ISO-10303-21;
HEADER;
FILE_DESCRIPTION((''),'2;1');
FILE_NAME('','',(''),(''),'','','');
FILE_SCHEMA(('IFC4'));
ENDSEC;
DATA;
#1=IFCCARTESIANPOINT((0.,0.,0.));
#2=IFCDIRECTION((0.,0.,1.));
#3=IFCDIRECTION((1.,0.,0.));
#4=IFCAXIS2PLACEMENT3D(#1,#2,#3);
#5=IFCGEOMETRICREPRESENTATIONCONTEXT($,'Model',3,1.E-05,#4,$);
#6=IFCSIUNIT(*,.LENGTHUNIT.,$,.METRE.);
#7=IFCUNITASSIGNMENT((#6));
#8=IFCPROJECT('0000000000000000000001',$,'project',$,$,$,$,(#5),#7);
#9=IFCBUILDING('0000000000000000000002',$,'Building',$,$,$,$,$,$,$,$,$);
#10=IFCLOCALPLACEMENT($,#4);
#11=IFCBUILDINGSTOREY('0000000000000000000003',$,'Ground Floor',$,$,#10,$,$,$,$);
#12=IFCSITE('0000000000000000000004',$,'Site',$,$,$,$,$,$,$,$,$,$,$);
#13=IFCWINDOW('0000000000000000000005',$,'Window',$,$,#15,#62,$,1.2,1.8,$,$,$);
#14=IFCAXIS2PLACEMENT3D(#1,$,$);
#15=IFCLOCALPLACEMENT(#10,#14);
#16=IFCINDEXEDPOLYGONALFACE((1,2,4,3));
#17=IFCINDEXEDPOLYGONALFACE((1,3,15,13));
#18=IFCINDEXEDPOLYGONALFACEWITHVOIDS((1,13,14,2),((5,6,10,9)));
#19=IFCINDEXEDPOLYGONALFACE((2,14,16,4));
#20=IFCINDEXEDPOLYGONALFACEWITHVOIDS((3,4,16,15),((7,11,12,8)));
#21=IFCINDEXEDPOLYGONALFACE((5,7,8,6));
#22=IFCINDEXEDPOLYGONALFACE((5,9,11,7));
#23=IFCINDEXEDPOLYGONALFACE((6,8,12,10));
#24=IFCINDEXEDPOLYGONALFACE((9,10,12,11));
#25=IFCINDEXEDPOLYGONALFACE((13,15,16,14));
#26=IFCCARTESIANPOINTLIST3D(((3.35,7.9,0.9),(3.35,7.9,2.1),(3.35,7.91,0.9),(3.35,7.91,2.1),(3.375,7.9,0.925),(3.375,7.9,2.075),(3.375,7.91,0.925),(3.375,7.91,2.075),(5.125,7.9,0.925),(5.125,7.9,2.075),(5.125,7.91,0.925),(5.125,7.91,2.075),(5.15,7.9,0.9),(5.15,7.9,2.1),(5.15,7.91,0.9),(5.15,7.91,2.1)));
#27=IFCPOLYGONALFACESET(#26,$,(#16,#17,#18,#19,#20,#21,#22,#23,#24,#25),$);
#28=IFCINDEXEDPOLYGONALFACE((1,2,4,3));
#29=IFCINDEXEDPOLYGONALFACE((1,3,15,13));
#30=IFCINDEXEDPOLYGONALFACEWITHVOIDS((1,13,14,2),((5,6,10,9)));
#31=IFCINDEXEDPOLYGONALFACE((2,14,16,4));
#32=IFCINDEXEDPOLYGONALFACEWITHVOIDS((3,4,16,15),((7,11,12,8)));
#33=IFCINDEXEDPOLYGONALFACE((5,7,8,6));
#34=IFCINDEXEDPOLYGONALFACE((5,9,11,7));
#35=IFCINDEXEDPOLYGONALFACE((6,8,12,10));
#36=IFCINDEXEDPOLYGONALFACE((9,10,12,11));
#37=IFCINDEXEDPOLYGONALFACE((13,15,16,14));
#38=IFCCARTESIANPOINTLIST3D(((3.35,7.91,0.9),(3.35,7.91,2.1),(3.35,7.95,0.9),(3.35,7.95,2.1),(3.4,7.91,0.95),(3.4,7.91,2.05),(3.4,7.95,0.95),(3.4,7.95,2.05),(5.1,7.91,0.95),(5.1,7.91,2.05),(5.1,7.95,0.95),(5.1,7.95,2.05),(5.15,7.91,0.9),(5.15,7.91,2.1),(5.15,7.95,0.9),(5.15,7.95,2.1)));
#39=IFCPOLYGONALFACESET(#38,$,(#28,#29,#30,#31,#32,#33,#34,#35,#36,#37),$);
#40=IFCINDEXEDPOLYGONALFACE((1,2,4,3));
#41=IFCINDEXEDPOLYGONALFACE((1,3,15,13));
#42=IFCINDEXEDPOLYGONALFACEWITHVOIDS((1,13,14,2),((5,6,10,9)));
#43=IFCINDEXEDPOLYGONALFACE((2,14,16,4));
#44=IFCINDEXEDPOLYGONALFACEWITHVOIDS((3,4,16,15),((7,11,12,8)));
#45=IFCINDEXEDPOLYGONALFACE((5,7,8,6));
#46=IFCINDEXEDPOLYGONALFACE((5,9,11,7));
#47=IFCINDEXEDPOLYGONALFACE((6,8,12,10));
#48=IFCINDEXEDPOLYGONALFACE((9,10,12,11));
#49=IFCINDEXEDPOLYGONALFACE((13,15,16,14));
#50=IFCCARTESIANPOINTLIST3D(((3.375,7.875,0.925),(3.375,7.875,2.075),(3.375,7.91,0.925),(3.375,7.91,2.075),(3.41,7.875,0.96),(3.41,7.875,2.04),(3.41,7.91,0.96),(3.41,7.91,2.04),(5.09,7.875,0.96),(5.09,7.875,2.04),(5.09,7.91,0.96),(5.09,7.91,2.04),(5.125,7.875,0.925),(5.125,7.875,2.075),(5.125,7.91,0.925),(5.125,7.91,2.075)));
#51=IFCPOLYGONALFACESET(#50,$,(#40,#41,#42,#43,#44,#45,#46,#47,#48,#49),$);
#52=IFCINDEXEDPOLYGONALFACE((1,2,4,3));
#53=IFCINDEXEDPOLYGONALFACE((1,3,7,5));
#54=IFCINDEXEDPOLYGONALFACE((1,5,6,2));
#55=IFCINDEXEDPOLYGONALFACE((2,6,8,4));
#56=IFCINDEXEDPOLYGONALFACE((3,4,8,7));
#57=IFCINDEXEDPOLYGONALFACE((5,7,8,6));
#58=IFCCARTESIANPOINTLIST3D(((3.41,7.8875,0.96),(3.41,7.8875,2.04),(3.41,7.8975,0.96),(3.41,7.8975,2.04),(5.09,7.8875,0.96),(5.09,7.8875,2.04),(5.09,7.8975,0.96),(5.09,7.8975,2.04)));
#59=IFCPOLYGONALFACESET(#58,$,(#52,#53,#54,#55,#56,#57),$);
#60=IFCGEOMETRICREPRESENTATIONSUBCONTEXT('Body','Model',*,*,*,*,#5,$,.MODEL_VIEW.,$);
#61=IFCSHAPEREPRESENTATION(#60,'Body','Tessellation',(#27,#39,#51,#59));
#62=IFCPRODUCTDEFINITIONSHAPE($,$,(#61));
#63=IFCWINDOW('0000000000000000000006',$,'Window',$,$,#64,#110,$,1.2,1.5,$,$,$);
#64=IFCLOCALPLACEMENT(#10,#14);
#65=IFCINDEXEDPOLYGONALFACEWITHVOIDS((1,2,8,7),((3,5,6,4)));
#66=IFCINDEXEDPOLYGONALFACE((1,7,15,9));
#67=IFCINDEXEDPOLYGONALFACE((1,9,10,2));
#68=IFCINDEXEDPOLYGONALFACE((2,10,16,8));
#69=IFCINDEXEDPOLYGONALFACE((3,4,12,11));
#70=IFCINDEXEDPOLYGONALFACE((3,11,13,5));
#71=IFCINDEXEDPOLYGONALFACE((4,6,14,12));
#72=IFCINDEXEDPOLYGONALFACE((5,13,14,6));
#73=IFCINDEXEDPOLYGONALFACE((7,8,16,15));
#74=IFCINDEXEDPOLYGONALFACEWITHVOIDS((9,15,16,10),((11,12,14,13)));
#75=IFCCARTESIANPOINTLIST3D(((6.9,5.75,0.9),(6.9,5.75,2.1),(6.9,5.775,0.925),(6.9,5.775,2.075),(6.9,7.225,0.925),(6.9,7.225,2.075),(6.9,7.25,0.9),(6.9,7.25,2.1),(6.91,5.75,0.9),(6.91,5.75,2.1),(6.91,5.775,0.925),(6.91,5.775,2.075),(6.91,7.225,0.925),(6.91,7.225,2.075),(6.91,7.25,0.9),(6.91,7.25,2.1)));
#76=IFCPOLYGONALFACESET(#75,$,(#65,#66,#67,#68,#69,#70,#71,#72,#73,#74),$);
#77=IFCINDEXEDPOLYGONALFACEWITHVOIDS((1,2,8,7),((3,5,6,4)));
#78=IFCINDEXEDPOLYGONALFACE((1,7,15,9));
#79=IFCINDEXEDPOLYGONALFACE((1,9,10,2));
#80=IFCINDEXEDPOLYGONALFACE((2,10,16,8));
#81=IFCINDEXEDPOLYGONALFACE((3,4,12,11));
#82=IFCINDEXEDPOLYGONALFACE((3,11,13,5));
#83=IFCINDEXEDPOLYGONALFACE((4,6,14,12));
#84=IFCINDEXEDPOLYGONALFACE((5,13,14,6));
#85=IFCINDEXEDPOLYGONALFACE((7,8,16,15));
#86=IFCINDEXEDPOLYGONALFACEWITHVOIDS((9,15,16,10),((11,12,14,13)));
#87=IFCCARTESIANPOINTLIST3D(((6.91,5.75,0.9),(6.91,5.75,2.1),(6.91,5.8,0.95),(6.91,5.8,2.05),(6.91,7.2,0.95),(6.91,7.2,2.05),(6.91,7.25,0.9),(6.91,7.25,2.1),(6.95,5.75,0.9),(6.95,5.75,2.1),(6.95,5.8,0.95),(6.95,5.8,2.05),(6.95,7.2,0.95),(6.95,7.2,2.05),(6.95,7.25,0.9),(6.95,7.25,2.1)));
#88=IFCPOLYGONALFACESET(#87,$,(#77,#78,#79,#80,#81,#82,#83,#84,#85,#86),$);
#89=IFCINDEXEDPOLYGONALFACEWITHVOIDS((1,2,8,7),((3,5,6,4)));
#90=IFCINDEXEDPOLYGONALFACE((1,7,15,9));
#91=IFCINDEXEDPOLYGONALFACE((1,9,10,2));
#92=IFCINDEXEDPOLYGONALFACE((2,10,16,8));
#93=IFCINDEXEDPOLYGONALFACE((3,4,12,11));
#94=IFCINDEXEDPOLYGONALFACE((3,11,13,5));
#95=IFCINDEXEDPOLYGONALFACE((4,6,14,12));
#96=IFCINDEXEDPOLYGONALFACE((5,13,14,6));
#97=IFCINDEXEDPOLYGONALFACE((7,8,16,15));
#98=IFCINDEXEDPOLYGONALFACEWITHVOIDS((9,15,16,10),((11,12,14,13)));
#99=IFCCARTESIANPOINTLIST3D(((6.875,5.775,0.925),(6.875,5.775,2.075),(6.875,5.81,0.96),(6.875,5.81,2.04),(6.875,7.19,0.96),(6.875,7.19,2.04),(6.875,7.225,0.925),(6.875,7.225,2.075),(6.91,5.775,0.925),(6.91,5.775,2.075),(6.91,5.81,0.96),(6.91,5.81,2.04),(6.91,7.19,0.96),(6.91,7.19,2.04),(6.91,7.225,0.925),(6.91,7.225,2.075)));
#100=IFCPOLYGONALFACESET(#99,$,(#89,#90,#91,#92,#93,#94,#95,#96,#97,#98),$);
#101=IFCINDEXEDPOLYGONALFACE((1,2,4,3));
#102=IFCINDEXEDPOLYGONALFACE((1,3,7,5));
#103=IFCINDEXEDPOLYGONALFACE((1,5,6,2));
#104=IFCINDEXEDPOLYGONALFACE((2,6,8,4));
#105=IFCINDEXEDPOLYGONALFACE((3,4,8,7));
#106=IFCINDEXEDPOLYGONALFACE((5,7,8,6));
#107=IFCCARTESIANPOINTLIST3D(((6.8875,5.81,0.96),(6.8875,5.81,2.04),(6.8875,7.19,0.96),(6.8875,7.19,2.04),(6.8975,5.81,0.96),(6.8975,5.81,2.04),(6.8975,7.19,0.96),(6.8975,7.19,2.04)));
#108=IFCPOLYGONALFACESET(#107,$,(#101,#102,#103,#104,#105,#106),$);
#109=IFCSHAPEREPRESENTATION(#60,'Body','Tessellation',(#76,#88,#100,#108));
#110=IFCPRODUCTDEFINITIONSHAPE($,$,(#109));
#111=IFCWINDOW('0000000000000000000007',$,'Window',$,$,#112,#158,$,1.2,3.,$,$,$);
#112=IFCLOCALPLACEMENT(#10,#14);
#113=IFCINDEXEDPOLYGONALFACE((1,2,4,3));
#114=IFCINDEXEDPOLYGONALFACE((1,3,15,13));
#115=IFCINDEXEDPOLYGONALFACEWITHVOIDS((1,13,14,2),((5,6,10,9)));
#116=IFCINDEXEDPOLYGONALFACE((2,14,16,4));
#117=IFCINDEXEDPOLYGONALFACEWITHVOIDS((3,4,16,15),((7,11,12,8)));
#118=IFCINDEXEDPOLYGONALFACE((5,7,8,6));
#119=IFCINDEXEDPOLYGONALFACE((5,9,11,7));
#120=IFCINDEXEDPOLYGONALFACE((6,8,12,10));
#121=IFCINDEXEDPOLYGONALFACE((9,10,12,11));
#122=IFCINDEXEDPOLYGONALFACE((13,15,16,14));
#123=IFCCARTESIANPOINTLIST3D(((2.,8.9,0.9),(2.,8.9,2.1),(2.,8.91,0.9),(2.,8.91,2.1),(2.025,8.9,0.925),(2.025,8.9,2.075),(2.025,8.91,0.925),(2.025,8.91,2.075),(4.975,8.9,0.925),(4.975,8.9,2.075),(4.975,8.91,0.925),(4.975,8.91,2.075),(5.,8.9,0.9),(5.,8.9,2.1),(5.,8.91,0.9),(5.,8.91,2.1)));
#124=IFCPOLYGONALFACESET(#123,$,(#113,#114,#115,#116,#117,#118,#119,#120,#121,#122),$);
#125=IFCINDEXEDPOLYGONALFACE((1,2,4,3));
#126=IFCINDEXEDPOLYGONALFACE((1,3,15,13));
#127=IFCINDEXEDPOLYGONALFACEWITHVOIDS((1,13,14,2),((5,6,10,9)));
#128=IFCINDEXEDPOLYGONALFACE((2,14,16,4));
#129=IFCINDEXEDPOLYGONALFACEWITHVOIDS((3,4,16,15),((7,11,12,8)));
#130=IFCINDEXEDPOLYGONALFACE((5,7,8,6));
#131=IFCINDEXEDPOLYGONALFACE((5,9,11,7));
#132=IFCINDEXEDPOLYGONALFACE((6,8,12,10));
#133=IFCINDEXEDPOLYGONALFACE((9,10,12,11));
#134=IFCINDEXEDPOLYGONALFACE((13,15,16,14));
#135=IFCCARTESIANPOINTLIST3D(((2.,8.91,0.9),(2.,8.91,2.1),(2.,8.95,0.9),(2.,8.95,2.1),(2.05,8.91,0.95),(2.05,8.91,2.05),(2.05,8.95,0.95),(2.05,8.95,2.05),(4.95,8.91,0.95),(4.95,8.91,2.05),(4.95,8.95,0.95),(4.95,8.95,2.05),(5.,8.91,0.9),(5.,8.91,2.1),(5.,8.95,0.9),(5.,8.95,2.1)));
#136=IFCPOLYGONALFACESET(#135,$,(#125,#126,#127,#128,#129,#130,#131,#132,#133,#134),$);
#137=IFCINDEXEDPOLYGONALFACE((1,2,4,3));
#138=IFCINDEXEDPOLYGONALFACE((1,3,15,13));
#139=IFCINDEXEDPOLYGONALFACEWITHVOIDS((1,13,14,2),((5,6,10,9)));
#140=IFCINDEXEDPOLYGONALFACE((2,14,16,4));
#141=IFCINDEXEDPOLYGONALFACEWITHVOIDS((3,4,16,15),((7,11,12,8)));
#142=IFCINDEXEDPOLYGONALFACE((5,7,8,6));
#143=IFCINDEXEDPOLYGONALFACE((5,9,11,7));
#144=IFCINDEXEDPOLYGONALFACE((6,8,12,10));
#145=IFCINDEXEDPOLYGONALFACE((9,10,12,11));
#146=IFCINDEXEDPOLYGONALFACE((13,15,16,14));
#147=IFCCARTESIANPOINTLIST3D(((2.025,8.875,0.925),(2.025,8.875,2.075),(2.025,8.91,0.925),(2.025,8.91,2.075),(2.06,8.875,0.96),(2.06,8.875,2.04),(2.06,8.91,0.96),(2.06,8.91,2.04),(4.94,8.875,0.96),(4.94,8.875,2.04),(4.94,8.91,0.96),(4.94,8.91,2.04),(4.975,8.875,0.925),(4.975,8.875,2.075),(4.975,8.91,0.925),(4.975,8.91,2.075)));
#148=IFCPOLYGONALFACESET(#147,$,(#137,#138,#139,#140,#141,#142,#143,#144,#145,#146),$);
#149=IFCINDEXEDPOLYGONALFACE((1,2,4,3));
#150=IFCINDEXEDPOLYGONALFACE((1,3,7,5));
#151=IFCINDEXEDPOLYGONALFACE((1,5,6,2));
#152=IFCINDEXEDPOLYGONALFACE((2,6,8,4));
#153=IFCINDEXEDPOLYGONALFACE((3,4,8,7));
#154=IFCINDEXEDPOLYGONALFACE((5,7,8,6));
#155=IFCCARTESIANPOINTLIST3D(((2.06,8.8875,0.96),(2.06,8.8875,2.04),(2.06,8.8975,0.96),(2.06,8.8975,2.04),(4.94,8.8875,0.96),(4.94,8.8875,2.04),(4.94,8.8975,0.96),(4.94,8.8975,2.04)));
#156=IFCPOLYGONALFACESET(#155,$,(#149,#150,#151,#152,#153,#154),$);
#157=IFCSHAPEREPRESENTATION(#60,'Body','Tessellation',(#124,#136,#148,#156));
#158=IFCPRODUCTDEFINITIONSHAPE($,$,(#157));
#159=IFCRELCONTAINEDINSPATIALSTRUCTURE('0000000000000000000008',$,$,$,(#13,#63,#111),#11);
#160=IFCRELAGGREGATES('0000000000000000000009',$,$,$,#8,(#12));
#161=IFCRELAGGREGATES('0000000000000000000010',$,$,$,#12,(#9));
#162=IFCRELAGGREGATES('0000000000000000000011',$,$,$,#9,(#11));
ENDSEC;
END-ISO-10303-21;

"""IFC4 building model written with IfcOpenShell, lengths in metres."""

from ifc_helpers import new_model, si_unit, frame, origin_with_axes, place, context, subcontext, project, spatial, line, indexed_curve, outline, extrude, element, save


model = new_model("IFC4")

# Units and contexts
model_context = context("Model", 3, precision=1e-05, world=origin_with_axes())
body_context = subcontext(model_context, "Body", "Model", "MODEL_VIEW")
ifc_project = project(units=[si_unit("LENGTHUNIT", "METRE")], contexts=[model_context])

# Site, building, storey
site = spatial("IfcSite", under=ifc_project, Name="Site")
building = spatial("IfcBuilding", under=site, Name="Building")
storey_placement = place(None, origin_with_axes())
storey = spatial("IfcBuildingStorey", under=building, at=storey_placement, Name="Ground Floor")

# Windows
window_1_placement = place(storey_placement, frame((5.15, 8.0, 0.9), z_axis=(0.0, 0.0, 1.0), x_axis=(-1.0, 0.0, 0.0)))
element("IfcWindow", 1, at=window_1_placement, inside=storey, Name="Window", OverallHeight=1.2, OverallWidth=1.8, context=body_context, shape_type="SweptSolid", body=[
    extrude(outline(indexed_curve([(0.0, 0.0), (1.8, 0.0), (1.8, 1.2), (0.0, 1.2)], segments=[line(1, 2, 3, 4, 1)]), holes=[indexed_curve([(0.025, 0.025), (1.775, 0.025), (1.775, 1.175), (0.025, 1.175)], segments=[line(1, 2, 3, 4, 1)])]), frame((0.0, 0.09, 0.0), z_axis=(0.0, -1.0, 0.0), x_axis=(1.0, 0.0, 0.0)), (0.0, 0.0, -1.0), 0.01),
    extrude(outline(indexed_curve([(0.0, 0.0), (1.8, 0.0), (1.8, 1.2), (0.0, 1.2)], segments=[line(1, 2, 3, 4, 1)]), holes=[indexed_curve([(0.05, 0.05), (1.75, 0.05), (1.75, 1.15), (0.05, 1.15)], segments=[line(1, 2, 3, 4, 1)])]), frame((0.0, 0.05, 0.0), z_axis=(0.0, -1.0, 0.0), x_axis=(1.0, 0.0, 0.0)), (0.0, 0.0, -1.0), 0.04),
    extrude(outline(indexed_curve([(0.0, 0.0), (1.75, 0.0), (1.75, 1.15), (0.0, 1.15)], segments=[line(1, 2, 3, 4, 1)]), holes=[indexed_curve([(0.035, 0.035), (1.715, 0.035), (1.715, 1.115), (0.035, 1.115)], segments=[line(1, 2, 3, 4, 1)])]), frame((0.025, 0.09, 0.025), z_axis=(0.0, -1.0, 0.0), x_axis=(1.0, 0.0, 0.0)), (0.0, 0.0, -1.0), 0.035),
    extrude(outline(indexed_curve([(0.035, 0.035), (1.715, 0.035), (1.715, 1.115), (0.035, 1.115)], segments=[line(1, 2, 3, 4, 1)])), frame((0.025, 0.1025, 0.025), z_axis=(0.0, -1.0, 0.0), x_axis=(1.0, 0.0, 0.0)), (0.0, 0.0, -1.0), 0.01),
])
window_2_placement = place(storey_placement, frame((7.0, 5.75, 0.9), z_axis=(0.0, 0.0, 1.0), x_axis=(0.0, 1.0, 0.0)))
element("IfcWindow", 2, at=window_2_placement, inside=storey, Name="Window", OverallHeight=1.2, OverallWidth=1.5, context=body_context, shape_type="SweptSolid", body=[
    extrude(outline(indexed_curve([(0.0, 0.0), (1.5, 0.0), (1.5, 1.2), (0.0, 1.2)], segments=[line(1, 2, 3, 4, 1)]), holes=[indexed_curve([(0.025, 0.025), (1.475, 0.025), (1.475, 1.175), (0.025, 1.175)], segments=[line(1, 2, 3, 4, 1)])]), frame((0.0, 0.09, 0.0), z_axis=(0.0, -1.0, 0.0), x_axis=(1.0, 0.0, 0.0)), (0.0, 0.0, -1.0), 0.01),
    extrude(outline(indexed_curve([(0.0, 0.0), (1.5, 0.0), (1.5, 1.2), (0.0, 1.2)], segments=[line(1, 2, 3, 4, 1)]), holes=[indexed_curve([(0.05, 0.05), (1.45, 0.05), (1.45, 1.15), (0.05, 1.15)], segments=[line(1, 2, 3, 4, 1)])]), frame((0.0, 0.05, 0.0), z_axis=(0.0, -1.0, 0.0), x_axis=(1.0, 0.0, 0.0)), (0.0, 0.0, -1.0), 0.04),
    extrude(outline(indexed_curve([(0.0, 0.0), (1.45, 0.0), (1.45, 1.15), (0.0, 1.15)], segments=[line(1, 2, 3, 4, 1)]), holes=[indexed_curve([(0.035, 0.035), (1.415, 0.035), (1.415, 1.115), (0.035, 1.115)], segments=[line(1, 2, 3, 4, 1)])]), frame((0.025, 0.09, 0.025), z_axis=(0.0, -1.0, 0.0), x_axis=(1.0, 0.0, 0.0)), (0.0, 0.0, -1.0), 0.035),
    extrude(outline(indexed_curve([(0.035, 0.035), (1.415, 0.035), (1.415, 1.115), (0.035, 1.115)], segments=[line(1, 2, 3, 4, 1)])), frame((0.025, 0.1025, 0.025), z_axis=(0.0, -1.0, 0.0), x_axis=(1.0, 0.0, 0.0)), (0.0, 0.0, -1.0), 0.01),
])
window_3_placement = place(storey_placement, frame((5.0, 9.0, 0.9), z_axis=(0.0, 0.0, 1.0), x_axis=(-1.0, 0.0, 0.0)))
element("IfcWindow", 3, at=window_3_placement, inside=storey, Name="Window", OverallHeight=1.2, OverallWidth=3.0, context=body_context, shape_type="SweptSolid", body=[
    extrude(outline(indexed_curve([(0.0, 0.0), (3.0, 0.0), (3.0, 1.2), (0.0, 1.2)], segments=[line(1, 2, 3, 4, 1)]), holes=[indexed_curve([(0.025, 0.025), (2.975, 0.025), (2.975, 1.175), (0.025, 1.175)], segments=[line(1, 2, 3, 4, 1)])]), frame((0.0, 0.09, 0.0), z_axis=(0.0, -1.0, 0.0), x_axis=(1.0, 0.0, 0.0)), (0.0, 0.0, -1.0), 0.01),
    extrude(outline(indexed_curve([(0.0, 0.0), (3.0, 0.0), (3.0, 1.2), (0.0, 1.2)], segments=[line(1, 2, 3, 4, 1)]), holes=[indexed_curve([(0.05, 0.05), (2.95, 0.05), (2.95, 1.15), (0.05, 1.15)], segments=[line(1, 2, 3, 4, 1)])]), frame((0.0, 0.05, 0.0), z_axis=(0.0, -1.0, 0.0), x_axis=(1.0, 0.0, 0.0)), (0.0, 0.0, -1.0), 0.04),
    extrude(outline(indexed_curve([(0.0, 0.0), (2.95, 0.0), (2.95, 1.15), (0.0, 1.15)], segments=[line(1, 2, 3, 4, 1)]), holes=[indexed_curve([(0.035, 0.035), (2.915, 0.035), (2.915, 1.115), (0.035, 1.115)], segments=[line(1, 2, 3, 4, 1)])]), frame((0.025, 0.09, 0.025), z_axis=(0.0, -1.0, 0.0), x_axis=(1.0, 0.0, 0.0)), (0.0, 0.0, -1.0), 0.035),
    extrude(outline(indexed_curve([(0.035, 0.035), (2.915, 0.035), (2.915, 1.115), (0.035, 1.115)], segments=[line(1, 2, 3, 4, 1)])), frame((0.025, 0.1025, 0.025), z_axis=(0.0, -1.0, 0.0), x_axis=(1.0, 0.0, 0.0)), (0.0, 0.0, -1.0), 0.01),
])

save(model, "model.ifc")
